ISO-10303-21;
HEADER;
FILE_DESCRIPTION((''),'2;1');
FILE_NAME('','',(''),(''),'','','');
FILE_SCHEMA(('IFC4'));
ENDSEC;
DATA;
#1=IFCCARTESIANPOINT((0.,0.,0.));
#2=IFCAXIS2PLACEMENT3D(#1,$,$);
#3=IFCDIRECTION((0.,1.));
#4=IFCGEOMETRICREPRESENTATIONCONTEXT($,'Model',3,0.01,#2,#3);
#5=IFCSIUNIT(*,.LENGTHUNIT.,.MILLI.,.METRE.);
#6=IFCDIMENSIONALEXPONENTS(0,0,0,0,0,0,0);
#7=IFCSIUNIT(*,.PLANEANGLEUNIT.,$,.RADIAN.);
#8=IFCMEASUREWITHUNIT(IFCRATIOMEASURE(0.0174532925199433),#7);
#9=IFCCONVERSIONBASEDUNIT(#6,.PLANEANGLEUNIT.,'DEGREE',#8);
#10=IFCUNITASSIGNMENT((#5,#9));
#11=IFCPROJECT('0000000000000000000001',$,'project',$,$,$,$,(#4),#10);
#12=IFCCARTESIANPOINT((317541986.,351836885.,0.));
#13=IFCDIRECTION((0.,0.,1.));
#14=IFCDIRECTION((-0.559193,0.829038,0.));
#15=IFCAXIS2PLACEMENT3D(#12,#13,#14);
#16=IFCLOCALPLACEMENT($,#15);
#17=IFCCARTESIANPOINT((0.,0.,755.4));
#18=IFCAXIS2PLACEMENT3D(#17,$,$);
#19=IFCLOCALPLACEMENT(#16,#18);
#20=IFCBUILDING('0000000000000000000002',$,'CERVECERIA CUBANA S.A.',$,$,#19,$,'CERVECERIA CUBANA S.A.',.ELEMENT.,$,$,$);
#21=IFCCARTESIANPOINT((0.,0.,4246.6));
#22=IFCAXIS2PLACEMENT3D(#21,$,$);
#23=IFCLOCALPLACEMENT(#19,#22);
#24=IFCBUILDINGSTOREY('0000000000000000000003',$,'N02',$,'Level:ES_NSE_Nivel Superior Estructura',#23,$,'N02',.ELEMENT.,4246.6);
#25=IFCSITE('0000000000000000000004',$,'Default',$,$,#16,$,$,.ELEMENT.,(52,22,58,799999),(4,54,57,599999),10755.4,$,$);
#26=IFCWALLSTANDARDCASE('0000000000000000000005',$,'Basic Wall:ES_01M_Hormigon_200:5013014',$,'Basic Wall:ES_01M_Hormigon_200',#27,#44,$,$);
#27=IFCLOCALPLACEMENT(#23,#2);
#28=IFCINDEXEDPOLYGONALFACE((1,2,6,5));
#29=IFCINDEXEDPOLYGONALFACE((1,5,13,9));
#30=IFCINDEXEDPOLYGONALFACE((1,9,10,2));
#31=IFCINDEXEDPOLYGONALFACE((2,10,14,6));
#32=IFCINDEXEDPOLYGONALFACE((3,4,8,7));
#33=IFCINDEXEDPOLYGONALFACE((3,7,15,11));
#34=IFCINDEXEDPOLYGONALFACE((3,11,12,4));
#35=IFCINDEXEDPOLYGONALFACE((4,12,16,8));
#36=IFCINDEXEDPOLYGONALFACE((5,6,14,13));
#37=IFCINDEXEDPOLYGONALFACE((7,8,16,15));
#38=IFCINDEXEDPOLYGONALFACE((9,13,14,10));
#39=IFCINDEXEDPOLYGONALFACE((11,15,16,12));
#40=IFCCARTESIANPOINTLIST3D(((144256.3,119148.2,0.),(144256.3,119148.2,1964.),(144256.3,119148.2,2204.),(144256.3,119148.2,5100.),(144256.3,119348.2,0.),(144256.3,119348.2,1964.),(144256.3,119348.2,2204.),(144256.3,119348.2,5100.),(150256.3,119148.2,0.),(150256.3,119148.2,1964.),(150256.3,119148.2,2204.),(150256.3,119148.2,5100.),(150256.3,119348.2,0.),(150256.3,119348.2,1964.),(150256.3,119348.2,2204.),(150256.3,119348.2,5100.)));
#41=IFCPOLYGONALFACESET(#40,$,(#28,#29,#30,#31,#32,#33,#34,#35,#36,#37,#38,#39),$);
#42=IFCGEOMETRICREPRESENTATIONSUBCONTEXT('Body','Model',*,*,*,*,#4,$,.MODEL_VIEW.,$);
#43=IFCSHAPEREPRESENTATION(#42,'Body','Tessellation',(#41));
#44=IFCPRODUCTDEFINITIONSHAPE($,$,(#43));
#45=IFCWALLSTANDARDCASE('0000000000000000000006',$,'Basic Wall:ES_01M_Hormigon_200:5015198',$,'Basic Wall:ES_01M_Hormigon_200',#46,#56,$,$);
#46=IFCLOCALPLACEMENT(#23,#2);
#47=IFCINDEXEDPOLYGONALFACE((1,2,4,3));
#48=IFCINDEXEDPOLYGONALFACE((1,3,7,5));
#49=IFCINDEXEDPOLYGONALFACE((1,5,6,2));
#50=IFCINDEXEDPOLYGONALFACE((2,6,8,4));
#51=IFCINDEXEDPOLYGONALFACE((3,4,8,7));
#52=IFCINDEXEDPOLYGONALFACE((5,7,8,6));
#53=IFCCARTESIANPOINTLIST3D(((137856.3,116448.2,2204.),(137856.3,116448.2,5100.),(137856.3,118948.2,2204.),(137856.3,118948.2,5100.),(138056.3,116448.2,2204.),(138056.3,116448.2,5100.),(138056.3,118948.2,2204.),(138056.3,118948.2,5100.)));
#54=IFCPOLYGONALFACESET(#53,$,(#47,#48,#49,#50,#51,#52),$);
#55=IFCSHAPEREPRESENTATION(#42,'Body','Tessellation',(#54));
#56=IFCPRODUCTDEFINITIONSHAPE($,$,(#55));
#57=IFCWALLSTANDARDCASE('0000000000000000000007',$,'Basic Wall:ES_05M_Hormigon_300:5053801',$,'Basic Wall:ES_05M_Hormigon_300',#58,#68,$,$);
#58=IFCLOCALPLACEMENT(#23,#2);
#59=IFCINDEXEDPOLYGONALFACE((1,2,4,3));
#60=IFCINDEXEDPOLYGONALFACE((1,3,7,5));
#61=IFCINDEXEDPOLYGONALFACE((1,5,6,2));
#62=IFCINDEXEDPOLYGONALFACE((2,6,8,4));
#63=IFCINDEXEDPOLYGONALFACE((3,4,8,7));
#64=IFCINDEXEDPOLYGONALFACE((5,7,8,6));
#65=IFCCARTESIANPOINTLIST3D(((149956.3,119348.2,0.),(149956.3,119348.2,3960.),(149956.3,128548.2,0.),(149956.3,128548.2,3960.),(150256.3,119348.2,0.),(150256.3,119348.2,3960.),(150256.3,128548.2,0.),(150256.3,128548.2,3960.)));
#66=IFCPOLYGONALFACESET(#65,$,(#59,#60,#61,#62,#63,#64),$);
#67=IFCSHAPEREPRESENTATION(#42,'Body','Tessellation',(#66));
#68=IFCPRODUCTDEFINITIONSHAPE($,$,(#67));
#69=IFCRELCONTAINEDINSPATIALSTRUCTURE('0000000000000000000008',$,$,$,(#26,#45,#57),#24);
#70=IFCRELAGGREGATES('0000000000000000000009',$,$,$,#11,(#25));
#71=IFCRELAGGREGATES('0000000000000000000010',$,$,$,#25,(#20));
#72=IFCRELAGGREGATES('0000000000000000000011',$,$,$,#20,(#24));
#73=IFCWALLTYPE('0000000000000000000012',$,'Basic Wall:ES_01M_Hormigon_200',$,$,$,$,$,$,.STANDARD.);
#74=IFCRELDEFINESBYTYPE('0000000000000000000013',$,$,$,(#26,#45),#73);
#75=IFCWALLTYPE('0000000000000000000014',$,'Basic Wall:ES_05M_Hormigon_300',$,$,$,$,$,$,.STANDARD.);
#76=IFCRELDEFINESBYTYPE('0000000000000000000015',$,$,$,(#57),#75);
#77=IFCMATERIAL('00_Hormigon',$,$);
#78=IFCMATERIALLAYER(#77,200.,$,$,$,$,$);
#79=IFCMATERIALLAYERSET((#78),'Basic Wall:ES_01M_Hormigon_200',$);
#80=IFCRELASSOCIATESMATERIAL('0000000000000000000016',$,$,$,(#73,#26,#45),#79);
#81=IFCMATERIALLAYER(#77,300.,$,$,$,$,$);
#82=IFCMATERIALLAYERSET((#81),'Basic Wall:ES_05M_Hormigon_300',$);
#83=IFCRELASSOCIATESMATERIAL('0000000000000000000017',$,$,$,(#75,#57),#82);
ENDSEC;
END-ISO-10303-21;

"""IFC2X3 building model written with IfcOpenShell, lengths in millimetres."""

from ifc_helpers import new_model, entity, si_unit, converted_unit, direction, frame, frame_2d, origin, place, context, subcontext, project, spatial, rectangle, extrude, material, layer, layer_set, layer_usage, type_object, element, save


model = new_model("IFC2X3")

# Units and contexts
model_context = context("Model", 3, precision=0.01, world=origin(), true_north=direction((0.0, 1.0)))
body_context = subcontext(model_context, "Body", "Model", "MODEL_VIEW")
ifc_project = project(units=[si_unit("LENGTHUNIT", "METRE", prefix="MILLI"), converted_unit("PLANEANGLEUNIT", "DEGREE", entity("IfcRatioMeasure", 0.0174532925199433), si_unit("PLANEANGLEUNIT", "RADIAN"), dimensions=[0, 0, 0, 0, 0, 0, 0])], contexts=[model_context])

# Site, building, storey
site_placement = place(None, frame((317541986.0, 351836885.0, 0.0), z_axis=(0.0, 0.0, 1.0), x_axis=(-0.559193, 0.829038, 0.0)))
site = spatial("IfcSite", under=ifc_project, at=site_placement, Name="Default", CompositionType="ELEMENT", RefLatitude=(52, 22, 58, 799999), RefLongitude=(4, 54, 57, 599999), RefElevation=10755.4)
building_placement = place(site_placement, frame((0.0, 0.0, 755.4)))
building = spatial("IfcBuilding", under=site, at=building_placement, Name="CERVECERIA CUBANA S.A.", LongName="CERVECERIA CUBANA S.A.", CompositionType="ELEMENT")
storey_placement = place(building_placement, frame((0.0, 0.0, 4246.6)))
storey = spatial("IfcBuildingStorey", under=building, at=storey_placement, Name="N02", ObjectType="Level:ES_NSE_Nivel Superior Estructura", LongName="N02", CompositionType="ELEMENT", Elevation=4246.6)

# Shared definitions
ifc_material_1 = material(Name="00_Hormigon")

# Shared definitions
ifc_layer_1 = layer(ifc_material_1, 200.0)
ifc_layer_set_1 = layer_set([ifc_layer_1], Name="Basic Wall:ES_01M_Hormigon_200")
wall_type_1 = type_object("IfcWallType", Name="Basic Wall:ES_01M_Hormigon_200", PredefinedType="STANDARD", material=ifc_layer_set_1)

# Wall, opening
ifc_layer_usage_1 = layer_usage(ifc_layer_set_1, "AXIS2", "NEGATIVE", 100.0)
wall_1_placement = place(storey_placement, frame((144256.3, 119248.2, 0.0)))
wall_1 = element("IfcWallStandardCase", 1, at=wall_1_placement, inside=storey, type_object=wall_type_1, material=ifc_layer_usage_1, Name="Basic Wall:ES_01M_Hormigon_200:5013014", ObjectType="Basic Wall:ES_01M_Hormigon_200", context=body_context, shape_type="SweptSolid", body=[
    extrude(rectangle(XDim=6000.0, YDim=200.0, at=frame_2d((3000.0, 0.0), x_axis=(-1.0, 0.0))), origin(), (0.0, 0.0, 1.0), 5100.0),
])
opening_1_placement = place(storey_placement, frame((144256.3, 119248.2, 0.0)))
element("IfcOpeningElement", 2, at=opening_1_placement, cuts=wall_1, ObjectType="Opening", context=body_context, shape_type="SweptSolid", body=[
    extrude(rectangle(XDim=6000.0, YDim=200.0, at=frame_2d((0.0, 0.0), x_axis=(1.0, 0.0))), frame((3000.0, 0.0, 1964.0)), (0.0, 0.0, 1.0), 240.0),
])

# Walls
ifc_layer_usage_2 = layer_usage(ifc_layer_set_1, "AXIS2", "NEGATIVE", 100.0)
wall_2_placement = place(storey_placement, frame((137956.3, 118948.2, 2204.0), z_axis=(0.0, 0.0, 1.0), x_axis=(0.0, -1.0, 0.0)))
element("IfcWallStandardCase", 3, at=wall_2_placement, inside=storey, type_object=wall_type_1, material=ifc_layer_usage_2, Name="Basic Wall:ES_01M_Hormigon_200:5015198", ObjectType="Basic Wall:ES_01M_Hormigon_200", context=body_context, shape_type="SweptSolid", body=[
    extrude(rectangle(XDim=2500.0, YDim=200.0, at=frame_2d((1250.0, 0.0), x_axis=(-1.0, 0.0))), origin(), (0.0, 0.0, 1.0), 2896.0),
])
ifc_layer_2 = layer(ifc_material_1, 300.0)
ifc_layer_set_2 = layer_set([ifc_layer_2], Name="Basic Wall:ES_05M_Hormigon_300")
ifc_layer_usage_3 = layer_usage(ifc_layer_set_2, "AXIS2", "NEGATIVE", 150.0)
wall_type_2 = type_object("IfcWallType", Name="Basic Wall:ES_05M_Hormigon_300", PredefinedType="STANDARD", material=ifc_layer_set_2)
wall_3_placement = place(storey_placement, frame((150106.3, 128548.2, 0.0), z_axis=(0.0, 0.0, 1.0), x_axis=(0.0, -1.0, 0.0)))
element("IfcWallStandardCase", 4, at=wall_3_placement, inside=storey, type_object=wall_type_2, material=ifc_layer_usage_3, Name="Basic Wall:ES_05M_Hormigon_300:5053801", ObjectType="Basic Wall:ES_05M_Hormigon_300", context=body_context, shape_type="SweptSolid", body=[
    extrude(rectangle(XDim=9200.0, YDim=300.0, at=frame_2d((4600.0, 0.0), x_axis=(-1.0, 0.0))), origin(), (0.0, 0.0, 1.0), 3960.0),
])

save(model, "model.ifc")
